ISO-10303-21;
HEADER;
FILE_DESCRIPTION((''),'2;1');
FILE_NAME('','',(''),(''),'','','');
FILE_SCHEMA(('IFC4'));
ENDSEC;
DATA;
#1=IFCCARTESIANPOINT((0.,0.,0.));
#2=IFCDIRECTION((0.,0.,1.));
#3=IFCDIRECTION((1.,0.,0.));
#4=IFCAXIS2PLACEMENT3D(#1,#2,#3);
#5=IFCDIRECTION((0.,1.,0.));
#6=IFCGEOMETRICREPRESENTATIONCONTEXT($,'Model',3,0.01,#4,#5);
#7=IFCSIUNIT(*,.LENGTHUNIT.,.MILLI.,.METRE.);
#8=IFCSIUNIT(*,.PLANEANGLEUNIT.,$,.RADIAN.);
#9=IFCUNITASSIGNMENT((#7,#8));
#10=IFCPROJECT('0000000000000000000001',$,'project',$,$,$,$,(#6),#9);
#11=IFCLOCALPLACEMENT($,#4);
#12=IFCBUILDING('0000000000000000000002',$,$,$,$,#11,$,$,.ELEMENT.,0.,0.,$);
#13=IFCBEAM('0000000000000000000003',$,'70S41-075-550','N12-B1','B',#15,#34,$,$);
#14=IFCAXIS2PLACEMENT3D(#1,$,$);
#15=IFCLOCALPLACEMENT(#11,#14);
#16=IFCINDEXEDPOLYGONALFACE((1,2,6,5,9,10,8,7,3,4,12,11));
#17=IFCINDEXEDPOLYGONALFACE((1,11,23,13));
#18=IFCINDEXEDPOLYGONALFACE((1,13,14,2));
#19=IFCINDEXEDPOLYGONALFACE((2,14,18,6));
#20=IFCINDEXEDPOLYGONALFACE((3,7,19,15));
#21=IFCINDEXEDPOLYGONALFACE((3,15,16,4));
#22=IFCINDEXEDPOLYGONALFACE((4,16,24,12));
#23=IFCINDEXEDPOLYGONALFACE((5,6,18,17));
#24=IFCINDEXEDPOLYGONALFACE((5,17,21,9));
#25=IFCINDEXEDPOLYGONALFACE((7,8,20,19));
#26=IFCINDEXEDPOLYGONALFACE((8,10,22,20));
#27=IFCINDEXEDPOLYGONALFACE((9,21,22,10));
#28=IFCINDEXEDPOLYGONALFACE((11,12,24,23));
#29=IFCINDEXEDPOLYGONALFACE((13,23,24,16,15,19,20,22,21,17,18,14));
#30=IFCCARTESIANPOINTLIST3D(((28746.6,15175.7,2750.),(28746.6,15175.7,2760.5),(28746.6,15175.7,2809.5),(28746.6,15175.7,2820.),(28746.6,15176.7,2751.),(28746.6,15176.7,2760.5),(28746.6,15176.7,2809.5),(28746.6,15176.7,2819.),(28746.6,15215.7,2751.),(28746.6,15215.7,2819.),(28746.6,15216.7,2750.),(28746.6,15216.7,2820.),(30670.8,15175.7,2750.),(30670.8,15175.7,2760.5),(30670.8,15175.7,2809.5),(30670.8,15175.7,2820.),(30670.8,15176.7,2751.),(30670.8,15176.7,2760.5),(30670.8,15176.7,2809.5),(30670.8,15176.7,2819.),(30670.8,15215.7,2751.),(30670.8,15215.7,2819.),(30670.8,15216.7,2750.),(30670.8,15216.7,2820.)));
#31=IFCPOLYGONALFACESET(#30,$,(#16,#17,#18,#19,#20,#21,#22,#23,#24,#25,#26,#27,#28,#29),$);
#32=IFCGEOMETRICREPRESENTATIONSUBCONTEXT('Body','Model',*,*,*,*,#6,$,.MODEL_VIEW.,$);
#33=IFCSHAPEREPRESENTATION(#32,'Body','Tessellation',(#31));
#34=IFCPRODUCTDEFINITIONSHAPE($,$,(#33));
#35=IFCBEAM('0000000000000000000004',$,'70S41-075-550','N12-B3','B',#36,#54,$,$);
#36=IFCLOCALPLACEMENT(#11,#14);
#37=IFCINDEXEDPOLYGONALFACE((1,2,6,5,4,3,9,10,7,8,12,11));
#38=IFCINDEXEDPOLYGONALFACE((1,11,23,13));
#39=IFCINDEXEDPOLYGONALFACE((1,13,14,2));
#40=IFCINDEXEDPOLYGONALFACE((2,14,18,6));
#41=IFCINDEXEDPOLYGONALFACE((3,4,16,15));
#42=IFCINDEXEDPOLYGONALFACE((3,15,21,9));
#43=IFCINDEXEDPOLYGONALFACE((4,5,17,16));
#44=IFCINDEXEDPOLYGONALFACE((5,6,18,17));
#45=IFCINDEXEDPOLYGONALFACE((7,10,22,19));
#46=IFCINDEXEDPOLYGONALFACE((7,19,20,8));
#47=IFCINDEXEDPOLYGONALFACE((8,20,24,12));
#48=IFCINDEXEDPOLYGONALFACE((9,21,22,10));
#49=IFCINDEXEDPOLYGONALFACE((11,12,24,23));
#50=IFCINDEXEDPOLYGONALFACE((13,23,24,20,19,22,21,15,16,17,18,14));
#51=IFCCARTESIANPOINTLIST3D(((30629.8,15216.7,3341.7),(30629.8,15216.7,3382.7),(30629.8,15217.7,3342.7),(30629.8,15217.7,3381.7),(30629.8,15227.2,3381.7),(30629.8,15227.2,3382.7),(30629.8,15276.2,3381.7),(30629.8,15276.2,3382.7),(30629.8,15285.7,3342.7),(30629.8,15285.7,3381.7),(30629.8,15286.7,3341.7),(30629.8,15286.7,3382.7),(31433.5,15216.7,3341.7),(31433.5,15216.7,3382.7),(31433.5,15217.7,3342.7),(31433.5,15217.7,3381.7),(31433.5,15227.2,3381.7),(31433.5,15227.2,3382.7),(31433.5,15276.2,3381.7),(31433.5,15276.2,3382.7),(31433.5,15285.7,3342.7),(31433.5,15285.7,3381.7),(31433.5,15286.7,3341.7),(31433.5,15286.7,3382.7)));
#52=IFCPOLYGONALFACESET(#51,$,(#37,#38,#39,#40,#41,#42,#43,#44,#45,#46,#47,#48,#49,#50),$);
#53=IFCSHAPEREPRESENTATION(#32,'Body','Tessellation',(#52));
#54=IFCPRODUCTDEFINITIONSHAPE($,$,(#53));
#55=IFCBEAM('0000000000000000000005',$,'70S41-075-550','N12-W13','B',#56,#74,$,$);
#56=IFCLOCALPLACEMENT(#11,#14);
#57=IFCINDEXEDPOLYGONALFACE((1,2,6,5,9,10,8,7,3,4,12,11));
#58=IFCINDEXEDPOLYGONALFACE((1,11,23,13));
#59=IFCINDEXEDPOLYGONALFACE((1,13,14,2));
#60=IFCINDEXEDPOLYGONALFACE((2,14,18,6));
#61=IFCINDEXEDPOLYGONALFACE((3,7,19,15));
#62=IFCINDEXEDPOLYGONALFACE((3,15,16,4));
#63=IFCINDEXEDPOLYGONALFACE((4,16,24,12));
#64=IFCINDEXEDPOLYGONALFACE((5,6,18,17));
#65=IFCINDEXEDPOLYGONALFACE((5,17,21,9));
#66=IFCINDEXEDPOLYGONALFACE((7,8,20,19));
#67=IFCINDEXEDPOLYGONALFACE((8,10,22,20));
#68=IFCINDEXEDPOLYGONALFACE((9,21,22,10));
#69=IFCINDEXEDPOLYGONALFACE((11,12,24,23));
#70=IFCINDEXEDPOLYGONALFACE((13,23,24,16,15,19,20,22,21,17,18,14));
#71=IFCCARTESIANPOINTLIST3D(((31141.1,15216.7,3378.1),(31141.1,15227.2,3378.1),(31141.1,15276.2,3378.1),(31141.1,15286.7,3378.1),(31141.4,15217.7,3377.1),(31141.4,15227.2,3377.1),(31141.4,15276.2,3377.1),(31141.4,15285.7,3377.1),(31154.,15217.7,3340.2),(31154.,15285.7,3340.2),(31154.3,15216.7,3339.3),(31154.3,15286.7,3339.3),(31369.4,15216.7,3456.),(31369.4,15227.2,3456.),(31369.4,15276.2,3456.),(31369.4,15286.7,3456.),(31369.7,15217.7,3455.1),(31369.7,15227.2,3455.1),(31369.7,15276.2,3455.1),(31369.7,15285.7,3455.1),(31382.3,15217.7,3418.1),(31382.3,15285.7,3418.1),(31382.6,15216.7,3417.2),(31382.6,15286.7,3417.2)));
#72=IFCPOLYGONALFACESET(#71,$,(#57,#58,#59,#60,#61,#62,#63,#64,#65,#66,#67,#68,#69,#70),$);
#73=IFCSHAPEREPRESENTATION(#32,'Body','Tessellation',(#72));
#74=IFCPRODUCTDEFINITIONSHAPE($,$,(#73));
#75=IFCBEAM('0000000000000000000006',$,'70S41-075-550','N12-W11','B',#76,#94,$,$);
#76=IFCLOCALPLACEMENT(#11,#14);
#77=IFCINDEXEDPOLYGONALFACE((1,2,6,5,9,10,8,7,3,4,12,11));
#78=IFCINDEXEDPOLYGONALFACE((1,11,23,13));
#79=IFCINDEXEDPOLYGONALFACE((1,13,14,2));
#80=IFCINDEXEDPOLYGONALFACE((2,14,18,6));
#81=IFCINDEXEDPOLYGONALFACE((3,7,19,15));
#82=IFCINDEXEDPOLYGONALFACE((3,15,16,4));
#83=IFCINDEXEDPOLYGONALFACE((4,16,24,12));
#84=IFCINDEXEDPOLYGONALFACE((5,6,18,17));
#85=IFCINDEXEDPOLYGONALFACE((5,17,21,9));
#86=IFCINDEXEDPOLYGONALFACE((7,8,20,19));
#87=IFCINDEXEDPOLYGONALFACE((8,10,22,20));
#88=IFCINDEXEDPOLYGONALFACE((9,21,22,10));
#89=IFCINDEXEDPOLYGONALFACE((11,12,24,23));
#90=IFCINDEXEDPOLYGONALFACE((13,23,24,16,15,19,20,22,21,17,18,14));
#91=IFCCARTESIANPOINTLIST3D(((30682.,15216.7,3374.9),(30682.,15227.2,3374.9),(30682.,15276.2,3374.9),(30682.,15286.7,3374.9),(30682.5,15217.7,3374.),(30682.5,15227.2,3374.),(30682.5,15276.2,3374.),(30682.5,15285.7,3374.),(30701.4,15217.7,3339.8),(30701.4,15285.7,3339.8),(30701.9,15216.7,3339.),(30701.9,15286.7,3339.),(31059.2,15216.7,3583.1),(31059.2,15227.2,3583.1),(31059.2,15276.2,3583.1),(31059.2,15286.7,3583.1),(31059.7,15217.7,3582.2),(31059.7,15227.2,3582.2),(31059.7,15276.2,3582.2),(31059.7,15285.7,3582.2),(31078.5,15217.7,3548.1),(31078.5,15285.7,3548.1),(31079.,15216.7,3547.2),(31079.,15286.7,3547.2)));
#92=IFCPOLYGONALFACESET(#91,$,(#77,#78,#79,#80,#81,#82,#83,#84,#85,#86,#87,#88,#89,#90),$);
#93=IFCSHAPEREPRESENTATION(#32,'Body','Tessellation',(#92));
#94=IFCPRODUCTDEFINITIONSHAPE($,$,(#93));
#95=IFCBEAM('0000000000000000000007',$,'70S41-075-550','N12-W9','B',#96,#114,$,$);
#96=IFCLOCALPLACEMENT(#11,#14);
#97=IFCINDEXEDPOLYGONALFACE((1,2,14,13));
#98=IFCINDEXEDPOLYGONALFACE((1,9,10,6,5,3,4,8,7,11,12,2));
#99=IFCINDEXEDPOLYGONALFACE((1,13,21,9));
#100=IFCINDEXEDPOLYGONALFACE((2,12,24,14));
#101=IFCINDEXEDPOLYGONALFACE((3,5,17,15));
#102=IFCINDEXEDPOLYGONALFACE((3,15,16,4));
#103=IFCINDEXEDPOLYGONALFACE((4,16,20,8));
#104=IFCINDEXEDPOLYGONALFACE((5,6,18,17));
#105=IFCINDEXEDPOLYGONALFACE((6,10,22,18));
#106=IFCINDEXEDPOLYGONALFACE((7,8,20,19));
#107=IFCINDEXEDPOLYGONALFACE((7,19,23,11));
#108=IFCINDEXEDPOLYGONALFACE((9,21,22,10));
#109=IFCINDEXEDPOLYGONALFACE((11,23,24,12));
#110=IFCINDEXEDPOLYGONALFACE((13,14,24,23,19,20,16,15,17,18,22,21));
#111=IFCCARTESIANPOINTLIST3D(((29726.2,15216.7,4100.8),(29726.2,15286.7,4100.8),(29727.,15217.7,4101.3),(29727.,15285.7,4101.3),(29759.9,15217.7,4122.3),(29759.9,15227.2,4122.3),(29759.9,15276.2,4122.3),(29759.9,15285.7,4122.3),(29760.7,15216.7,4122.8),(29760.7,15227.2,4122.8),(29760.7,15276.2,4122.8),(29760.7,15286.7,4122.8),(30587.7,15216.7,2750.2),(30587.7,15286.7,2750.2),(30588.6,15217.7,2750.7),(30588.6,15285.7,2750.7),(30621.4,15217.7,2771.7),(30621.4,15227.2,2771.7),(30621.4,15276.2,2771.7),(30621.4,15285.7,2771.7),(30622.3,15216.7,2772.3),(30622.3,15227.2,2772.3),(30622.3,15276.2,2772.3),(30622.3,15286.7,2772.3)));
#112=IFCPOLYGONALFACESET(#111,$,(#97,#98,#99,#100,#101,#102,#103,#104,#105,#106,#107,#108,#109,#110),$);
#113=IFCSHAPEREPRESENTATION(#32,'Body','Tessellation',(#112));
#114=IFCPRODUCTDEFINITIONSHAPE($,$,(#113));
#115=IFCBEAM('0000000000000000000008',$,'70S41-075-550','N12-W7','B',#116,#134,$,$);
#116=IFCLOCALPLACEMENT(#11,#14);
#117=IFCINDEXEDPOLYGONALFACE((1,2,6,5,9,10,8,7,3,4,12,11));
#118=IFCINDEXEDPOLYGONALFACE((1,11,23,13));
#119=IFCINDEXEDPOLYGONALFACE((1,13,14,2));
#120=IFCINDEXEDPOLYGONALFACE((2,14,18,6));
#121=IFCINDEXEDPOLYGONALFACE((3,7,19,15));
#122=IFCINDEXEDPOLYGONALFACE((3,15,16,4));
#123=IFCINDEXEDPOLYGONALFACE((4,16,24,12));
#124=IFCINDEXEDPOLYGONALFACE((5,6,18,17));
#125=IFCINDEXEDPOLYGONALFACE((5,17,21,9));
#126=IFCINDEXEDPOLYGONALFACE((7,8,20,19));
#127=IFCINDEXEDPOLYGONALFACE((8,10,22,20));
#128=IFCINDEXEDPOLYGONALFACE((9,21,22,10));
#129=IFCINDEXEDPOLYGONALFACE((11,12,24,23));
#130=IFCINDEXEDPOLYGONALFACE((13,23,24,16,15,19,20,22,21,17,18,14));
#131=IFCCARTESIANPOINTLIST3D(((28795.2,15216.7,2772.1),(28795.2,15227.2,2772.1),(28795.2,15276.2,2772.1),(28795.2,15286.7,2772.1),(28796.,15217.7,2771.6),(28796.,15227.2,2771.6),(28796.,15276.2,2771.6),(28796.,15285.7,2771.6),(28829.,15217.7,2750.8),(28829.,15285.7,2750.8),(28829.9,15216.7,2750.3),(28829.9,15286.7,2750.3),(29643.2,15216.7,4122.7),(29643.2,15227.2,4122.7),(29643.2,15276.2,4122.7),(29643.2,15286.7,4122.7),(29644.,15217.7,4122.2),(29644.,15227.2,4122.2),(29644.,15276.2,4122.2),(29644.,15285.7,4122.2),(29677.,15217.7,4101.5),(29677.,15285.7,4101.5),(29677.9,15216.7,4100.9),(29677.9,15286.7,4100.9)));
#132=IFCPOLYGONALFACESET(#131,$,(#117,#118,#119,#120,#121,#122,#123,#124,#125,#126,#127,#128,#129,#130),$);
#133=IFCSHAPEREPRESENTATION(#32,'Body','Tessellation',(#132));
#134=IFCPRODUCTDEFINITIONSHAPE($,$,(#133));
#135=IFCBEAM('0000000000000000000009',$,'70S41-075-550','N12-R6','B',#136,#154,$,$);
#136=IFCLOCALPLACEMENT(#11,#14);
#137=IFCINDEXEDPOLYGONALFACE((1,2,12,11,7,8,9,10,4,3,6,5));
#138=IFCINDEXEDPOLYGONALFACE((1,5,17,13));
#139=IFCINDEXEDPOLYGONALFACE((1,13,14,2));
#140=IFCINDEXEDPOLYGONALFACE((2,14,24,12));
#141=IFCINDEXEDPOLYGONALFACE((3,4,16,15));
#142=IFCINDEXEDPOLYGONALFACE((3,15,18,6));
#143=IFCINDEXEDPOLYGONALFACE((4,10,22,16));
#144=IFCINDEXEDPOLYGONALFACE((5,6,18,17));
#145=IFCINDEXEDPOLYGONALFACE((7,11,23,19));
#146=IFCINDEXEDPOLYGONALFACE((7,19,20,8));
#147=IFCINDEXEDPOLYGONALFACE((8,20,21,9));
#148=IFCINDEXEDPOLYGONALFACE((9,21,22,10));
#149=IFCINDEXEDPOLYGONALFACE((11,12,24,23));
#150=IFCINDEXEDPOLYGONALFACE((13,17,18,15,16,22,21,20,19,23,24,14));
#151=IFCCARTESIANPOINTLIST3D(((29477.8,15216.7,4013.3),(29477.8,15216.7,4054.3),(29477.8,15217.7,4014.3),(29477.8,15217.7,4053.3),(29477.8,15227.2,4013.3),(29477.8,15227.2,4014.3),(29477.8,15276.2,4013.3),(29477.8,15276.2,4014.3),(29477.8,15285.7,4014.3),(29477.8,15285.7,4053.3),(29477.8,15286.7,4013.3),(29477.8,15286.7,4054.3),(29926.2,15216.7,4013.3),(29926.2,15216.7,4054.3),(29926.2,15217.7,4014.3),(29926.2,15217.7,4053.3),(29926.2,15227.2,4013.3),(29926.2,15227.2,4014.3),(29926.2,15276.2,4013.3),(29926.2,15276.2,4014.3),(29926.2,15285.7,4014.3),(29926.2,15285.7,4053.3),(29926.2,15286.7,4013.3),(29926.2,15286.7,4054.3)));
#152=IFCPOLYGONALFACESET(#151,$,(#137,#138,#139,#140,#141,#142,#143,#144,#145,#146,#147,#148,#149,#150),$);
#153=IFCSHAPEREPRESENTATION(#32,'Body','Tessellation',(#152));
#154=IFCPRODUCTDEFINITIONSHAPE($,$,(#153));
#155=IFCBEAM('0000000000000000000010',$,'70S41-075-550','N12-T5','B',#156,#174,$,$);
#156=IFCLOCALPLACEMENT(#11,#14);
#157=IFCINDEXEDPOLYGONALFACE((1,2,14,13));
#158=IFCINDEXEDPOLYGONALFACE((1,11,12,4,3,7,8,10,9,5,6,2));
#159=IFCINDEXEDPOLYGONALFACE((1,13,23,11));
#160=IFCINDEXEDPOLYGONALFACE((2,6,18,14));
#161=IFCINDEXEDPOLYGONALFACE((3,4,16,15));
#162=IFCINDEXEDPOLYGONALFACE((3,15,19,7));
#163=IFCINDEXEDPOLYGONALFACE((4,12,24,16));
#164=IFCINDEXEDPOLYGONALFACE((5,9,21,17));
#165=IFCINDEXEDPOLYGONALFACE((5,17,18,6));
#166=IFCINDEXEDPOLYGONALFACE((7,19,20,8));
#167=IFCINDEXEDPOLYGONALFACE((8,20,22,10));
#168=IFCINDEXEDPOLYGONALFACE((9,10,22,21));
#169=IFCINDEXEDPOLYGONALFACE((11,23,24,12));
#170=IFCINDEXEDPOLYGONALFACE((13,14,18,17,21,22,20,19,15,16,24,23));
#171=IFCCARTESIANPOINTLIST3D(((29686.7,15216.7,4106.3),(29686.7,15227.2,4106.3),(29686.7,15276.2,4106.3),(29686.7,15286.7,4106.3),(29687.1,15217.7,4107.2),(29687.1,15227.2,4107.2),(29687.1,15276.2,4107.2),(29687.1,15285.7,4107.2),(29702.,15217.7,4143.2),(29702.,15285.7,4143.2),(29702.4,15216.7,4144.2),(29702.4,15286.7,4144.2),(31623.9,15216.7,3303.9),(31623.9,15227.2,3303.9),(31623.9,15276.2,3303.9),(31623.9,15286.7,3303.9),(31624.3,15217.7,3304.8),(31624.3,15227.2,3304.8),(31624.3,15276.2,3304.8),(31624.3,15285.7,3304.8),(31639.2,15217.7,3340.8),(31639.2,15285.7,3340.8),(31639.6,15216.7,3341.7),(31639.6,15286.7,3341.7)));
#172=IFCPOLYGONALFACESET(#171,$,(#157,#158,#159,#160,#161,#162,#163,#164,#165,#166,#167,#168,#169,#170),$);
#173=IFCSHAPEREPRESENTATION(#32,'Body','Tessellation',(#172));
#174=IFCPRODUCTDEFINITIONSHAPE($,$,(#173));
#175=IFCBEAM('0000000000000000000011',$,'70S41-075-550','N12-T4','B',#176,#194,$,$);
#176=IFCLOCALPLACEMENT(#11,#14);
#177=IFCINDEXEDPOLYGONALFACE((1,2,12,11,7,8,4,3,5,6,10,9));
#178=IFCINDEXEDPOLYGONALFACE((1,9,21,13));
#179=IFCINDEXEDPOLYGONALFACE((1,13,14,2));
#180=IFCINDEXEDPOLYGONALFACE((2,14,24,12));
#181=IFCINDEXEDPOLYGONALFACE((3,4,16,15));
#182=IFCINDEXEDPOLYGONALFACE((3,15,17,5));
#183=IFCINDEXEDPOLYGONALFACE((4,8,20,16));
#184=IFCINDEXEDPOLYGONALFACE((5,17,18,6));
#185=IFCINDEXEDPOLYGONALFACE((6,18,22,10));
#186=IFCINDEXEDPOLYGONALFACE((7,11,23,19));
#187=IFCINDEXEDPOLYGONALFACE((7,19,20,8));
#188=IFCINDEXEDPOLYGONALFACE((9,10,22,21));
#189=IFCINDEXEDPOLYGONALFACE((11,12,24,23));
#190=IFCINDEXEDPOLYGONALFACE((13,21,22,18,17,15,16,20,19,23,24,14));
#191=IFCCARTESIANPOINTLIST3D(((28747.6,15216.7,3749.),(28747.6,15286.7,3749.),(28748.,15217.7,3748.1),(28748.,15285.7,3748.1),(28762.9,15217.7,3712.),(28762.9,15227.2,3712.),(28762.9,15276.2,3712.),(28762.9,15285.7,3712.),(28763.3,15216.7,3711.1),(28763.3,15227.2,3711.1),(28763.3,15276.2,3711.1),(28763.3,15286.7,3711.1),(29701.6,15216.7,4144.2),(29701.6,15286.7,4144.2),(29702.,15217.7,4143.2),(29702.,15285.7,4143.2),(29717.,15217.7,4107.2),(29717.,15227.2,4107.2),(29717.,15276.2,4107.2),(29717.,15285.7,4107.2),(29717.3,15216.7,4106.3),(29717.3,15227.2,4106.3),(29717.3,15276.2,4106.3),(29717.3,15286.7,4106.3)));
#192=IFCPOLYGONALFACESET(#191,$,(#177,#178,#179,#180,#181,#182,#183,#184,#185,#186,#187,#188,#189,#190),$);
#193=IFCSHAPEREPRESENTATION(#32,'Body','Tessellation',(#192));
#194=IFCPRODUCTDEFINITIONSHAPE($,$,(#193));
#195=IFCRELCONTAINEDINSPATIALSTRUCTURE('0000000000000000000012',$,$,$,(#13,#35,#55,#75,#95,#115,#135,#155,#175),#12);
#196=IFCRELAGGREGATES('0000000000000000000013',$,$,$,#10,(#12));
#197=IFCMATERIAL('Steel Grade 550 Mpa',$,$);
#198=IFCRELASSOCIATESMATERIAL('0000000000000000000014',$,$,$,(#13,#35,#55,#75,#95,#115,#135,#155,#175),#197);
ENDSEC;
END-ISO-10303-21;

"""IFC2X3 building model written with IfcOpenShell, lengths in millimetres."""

from ifc_helpers import new_model, si_unit, direction, frame, origin, origin_with_axes, origin_2d_with_axis, place, context, subcontext, project, spatial, c_section, extrude, source, transform, mapped, material, element, save


model = new_model("IFC2X3")

# Units and contexts
model_context = context("Model", 3, precision=0.01, world=origin_with_axes(), true_north=direction((0.0, 1.0, 0.0)))
body_context = subcontext(model_context, "Body", "Model", "MODEL_VIEW")
ifc_project = project(units=[si_unit("LENGTHUNIT", "METRE", prefix="MILLI"), si_unit("PLANEANGLEUNIT", "RADIAN")], contexts=[model_context])

# Building
building_placement = place(None, origin_with_axes())
building = spatial("IfcBuilding", under=ifc_project, at=building_placement, CompositionType="ELEMENT", ElevationOfRefHeight=0.0, ElevationOfTerrain=0.0)

# Shared definitions
ifc_material = material(Name="Steel Grade 550 Mpa")

# Beams
shared_shape_1 = source(origin(), body_context, "Body", "SweptSolid", [
    extrude(c_section(Depth=70.0, Width=41.0, WallThickness=1.0, Girth=10.5, at=origin_2d_with_axis()), origin_with_axes(), (0.0, 0.0, 1.0), 1924.2),
])
beam_1_placement = place(None, frame((28746.6, 15196.2, 2785.0), z_axis=(1.0, 0.0, 0.0), x_axis=(0.0, -1.0, 0.0)))
element("IfcBeam", 1, at=beam_1_placement, inside=building, material=ifc_material, Name="70S41-075-550", Description="N12-B1", ObjectType="B", context=body_context, shape_type="MappedRepresentation", body=[
    mapped(shared_shape_1, transform((0.0, 0.0, 0.0), scale=1.0)),
])
shared_shape_2 = source(origin(), body_context, "Body", "SweptSolid", [
    extrude(c_section(Depth=70.0, Width=41.0, WallThickness=1.0, Girth=10.5, at=origin_2d_with_axis()), origin_with_axes(), (0.0, 0.0, 1.0), 803.6),
])
beam_2_placement = place(None, frame((30629.8, 15251.7, 3362.2), z_axis=(1.0, 0.0, 0.0), x_axis=(0.0, 0.0, 1.0)))
element("IfcBeam", 2, at=beam_2_placement, inside=building, material=ifc_material, Name="70S41-075-550", Description="N12-B3", ObjectType="B", context=body_context, shape_type="MappedRepresentation", body=[
    mapped(shared_shape_2, transform((0.0, 0.0, 0.0), scale=1.0)),
])
shared_shape_3 = source(origin(), body_context, "Body", "SweptSolid", [
    extrude(c_section(Depth=70.0, Width=41.0, WallThickness=1.0, Girth=10.5, at=origin_2d_with_axis()), origin_with_axes(), (0.0, 0.0, 1.0), 241.3),
])
beam_3_placement = place(None, frame((31147.7, 15251.7, 3358.7), z_axis=(0.946412, 0.0, 0.322961), x_axis=(-0.322961, 0.0, 0.946412)))
element("IfcBeam", 3, at=beam_3_placement, inside=building, material=ifc_material, Name="70S41-075-550", Description="N12-W13", ObjectType="B", context=body_context, shape_type="MappedRepresentation", body=[
    mapped(shared_shape_3, transform((0.0, 0.0, 0.0), scale=1.0)),
])
shared_shape_4 = source(origin(), body_context, "Body", "SweptSolid", [
    extrude(c_section(Depth=70.0, Width=41.0, WallThickness=1.0, Girth=10.5, at=origin_2d_with_axis()), origin_with_axes(), (0.0, 0.0, 1.0), 430.8),
])
beam_4_placement = place(None, frame((30691.9, 15251.7, 3356.9), z_axis=(0.875428, 0.0, 0.483348), x_axis=(-0.483348, 0.0, 0.875428)))
element("IfcBeam", 4, at=beam_4_placement, inside=building, material=ifc_material, Name="70S41-075-550", Description="N12-W11", ObjectType="B", context=body_context, shape_type="MappedRepresentation", body=[
    mapped(shared_shape_4, transform((0.0, 0.0, 0.0), scale=1.0)),
])
shared_shape_5 = source(origin(), body_context, "Body", "SweptSolid", [
    extrude(c_section(Depth=70.0, Width=41.0, WallThickness=1.0, Girth=10.5, at=origin_2d_with_axis()), origin_with_axes(), (0.0, 0.0, 1.0), 1602.0),
])
beam_5_placement = place(None, frame((29743.5, 15251.7, 4111.8), z_axis=(0.537802, 0.0, -0.843071), x_axis=(0.843071, 0.0, 0.537802)))
element("IfcBeam", 5, at=beam_5_placement, inside=building, material=ifc_material, Name="70S41-075-550", Description="N12-W9", ObjectType="B", context=body_context, shape_type="MappedRepresentation", body=[
    mapped(shared_shape_5, transform((0.0, 0.0, 0.0), scale=1.0)),
])
shared_shape_6 = source(origin(), body_context, "Body", "SweptSolid", [
    extrude(c_section(Depth=70.0, Width=41.0, WallThickness=1.0, Girth=10.5, at=origin_2d_with_axis()), origin_with_axes(), (0.0, 0.0, 1.0), 1594.8),
])
beam_6_placement = place(None, frame((28812.5, 15251.7, 2761.2), z_axis=(0.531732, 0.0, 0.846913), x_axis=(-0.846913, 0.0, 0.531732)))
element("IfcBeam", 6, at=beam_6_placement, inside=building, material=ifc_material, Name="70S41-075-550", Description="N12-W7", ObjectType="B", context=body_context, shape_type="MappedRepresentation", body=[
    mapped(shared_shape_6, transform((0.0, 0.0, 0.0), scale=1.0)),
])
shared_shape_7 = source(origin(), body_context, "Body", "SweptSolid", [
    extrude(c_section(Depth=70.0, Width=41.0, WallThickness=1.0, Girth=10.5, at=origin_2d_with_axis()), origin_with_axes(), (0.0, 0.0, 1.0), 448.4),
])
beam_7_placement = place(None, frame((29926.2, 15251.7, 4033.8), z_axis=(-1.0, 0.0, 0.0), x_axis=(0.0, 0.0, -1.0)))
element("IfcBeam", 7, at=beam_7_placement, inside=building, material=ifc_material, Name="70S41-075-550", Description="N12-R6", ObjectType="B", context=body_context, shape_type="MappedRepresentation", body=[
    mapped(shared_shape_7, transform((0.0, 0.0, 0.0), scale=1.0)),
])
shared_shape_8 = source(origin(), body_context, "Body", "SweptSolid", [
    extrude(c_section(Depth=70.0, Width=41.0, WallThickness=1.0, Girth=10.5, at=origin_2d_with_axis()), origin_with_axes(), (0.0, 0.0, 1.0), 2096.8),
])
beam_8_placement = place(None, frame((31631.8, 15251.7, 3322.8), z_axis=(-0.92388, 0.0, 0.382683), x_axis=(-0.382683, 0.0, -0.92388)))
element("IfcBeam", 8, at=beam_8_placement, inside=building, material=ifc_material, Name="70S41-075-550", Description="N12-T5", ObjectType="B", context=body_context, shape_type="MappedRepresentation", body=[
    mapped(shared_shape_8, transform((0.0, 0.0, 0.0), scale=1.0)),
])
shared_shape_9 = source(origin(), body_context, "Body", "SweptSolid", [
    extrude(c_section(Depth=70.0, Width=41.0, WallThickness=1.0, Girth=10.5, at=origin_2d_with_axis()), origin_with_axes(), (0.0, 0.0, 1.0), 1032.6),
])
beam_9_placement = place(None, frame((29709.5, 15251.7, 4125.2), z_axis=(-0.92388, 0.0, -0.382683), x_axis=(0.382683, 0.0, -0.92388)))
element("IfcBeam", 9, at=beam_9_placement, inside=building, material=ifc_material, Name="70S41-075-550", Description="N12-T4", ObjectType="B", context=body_context, shape_type="MappedRepresentation", body=[
    mapped(shared_shape_9, transform((0.0, 0.0, 0.0), scale=1.0)),
])

save(model, "model.ifc")
